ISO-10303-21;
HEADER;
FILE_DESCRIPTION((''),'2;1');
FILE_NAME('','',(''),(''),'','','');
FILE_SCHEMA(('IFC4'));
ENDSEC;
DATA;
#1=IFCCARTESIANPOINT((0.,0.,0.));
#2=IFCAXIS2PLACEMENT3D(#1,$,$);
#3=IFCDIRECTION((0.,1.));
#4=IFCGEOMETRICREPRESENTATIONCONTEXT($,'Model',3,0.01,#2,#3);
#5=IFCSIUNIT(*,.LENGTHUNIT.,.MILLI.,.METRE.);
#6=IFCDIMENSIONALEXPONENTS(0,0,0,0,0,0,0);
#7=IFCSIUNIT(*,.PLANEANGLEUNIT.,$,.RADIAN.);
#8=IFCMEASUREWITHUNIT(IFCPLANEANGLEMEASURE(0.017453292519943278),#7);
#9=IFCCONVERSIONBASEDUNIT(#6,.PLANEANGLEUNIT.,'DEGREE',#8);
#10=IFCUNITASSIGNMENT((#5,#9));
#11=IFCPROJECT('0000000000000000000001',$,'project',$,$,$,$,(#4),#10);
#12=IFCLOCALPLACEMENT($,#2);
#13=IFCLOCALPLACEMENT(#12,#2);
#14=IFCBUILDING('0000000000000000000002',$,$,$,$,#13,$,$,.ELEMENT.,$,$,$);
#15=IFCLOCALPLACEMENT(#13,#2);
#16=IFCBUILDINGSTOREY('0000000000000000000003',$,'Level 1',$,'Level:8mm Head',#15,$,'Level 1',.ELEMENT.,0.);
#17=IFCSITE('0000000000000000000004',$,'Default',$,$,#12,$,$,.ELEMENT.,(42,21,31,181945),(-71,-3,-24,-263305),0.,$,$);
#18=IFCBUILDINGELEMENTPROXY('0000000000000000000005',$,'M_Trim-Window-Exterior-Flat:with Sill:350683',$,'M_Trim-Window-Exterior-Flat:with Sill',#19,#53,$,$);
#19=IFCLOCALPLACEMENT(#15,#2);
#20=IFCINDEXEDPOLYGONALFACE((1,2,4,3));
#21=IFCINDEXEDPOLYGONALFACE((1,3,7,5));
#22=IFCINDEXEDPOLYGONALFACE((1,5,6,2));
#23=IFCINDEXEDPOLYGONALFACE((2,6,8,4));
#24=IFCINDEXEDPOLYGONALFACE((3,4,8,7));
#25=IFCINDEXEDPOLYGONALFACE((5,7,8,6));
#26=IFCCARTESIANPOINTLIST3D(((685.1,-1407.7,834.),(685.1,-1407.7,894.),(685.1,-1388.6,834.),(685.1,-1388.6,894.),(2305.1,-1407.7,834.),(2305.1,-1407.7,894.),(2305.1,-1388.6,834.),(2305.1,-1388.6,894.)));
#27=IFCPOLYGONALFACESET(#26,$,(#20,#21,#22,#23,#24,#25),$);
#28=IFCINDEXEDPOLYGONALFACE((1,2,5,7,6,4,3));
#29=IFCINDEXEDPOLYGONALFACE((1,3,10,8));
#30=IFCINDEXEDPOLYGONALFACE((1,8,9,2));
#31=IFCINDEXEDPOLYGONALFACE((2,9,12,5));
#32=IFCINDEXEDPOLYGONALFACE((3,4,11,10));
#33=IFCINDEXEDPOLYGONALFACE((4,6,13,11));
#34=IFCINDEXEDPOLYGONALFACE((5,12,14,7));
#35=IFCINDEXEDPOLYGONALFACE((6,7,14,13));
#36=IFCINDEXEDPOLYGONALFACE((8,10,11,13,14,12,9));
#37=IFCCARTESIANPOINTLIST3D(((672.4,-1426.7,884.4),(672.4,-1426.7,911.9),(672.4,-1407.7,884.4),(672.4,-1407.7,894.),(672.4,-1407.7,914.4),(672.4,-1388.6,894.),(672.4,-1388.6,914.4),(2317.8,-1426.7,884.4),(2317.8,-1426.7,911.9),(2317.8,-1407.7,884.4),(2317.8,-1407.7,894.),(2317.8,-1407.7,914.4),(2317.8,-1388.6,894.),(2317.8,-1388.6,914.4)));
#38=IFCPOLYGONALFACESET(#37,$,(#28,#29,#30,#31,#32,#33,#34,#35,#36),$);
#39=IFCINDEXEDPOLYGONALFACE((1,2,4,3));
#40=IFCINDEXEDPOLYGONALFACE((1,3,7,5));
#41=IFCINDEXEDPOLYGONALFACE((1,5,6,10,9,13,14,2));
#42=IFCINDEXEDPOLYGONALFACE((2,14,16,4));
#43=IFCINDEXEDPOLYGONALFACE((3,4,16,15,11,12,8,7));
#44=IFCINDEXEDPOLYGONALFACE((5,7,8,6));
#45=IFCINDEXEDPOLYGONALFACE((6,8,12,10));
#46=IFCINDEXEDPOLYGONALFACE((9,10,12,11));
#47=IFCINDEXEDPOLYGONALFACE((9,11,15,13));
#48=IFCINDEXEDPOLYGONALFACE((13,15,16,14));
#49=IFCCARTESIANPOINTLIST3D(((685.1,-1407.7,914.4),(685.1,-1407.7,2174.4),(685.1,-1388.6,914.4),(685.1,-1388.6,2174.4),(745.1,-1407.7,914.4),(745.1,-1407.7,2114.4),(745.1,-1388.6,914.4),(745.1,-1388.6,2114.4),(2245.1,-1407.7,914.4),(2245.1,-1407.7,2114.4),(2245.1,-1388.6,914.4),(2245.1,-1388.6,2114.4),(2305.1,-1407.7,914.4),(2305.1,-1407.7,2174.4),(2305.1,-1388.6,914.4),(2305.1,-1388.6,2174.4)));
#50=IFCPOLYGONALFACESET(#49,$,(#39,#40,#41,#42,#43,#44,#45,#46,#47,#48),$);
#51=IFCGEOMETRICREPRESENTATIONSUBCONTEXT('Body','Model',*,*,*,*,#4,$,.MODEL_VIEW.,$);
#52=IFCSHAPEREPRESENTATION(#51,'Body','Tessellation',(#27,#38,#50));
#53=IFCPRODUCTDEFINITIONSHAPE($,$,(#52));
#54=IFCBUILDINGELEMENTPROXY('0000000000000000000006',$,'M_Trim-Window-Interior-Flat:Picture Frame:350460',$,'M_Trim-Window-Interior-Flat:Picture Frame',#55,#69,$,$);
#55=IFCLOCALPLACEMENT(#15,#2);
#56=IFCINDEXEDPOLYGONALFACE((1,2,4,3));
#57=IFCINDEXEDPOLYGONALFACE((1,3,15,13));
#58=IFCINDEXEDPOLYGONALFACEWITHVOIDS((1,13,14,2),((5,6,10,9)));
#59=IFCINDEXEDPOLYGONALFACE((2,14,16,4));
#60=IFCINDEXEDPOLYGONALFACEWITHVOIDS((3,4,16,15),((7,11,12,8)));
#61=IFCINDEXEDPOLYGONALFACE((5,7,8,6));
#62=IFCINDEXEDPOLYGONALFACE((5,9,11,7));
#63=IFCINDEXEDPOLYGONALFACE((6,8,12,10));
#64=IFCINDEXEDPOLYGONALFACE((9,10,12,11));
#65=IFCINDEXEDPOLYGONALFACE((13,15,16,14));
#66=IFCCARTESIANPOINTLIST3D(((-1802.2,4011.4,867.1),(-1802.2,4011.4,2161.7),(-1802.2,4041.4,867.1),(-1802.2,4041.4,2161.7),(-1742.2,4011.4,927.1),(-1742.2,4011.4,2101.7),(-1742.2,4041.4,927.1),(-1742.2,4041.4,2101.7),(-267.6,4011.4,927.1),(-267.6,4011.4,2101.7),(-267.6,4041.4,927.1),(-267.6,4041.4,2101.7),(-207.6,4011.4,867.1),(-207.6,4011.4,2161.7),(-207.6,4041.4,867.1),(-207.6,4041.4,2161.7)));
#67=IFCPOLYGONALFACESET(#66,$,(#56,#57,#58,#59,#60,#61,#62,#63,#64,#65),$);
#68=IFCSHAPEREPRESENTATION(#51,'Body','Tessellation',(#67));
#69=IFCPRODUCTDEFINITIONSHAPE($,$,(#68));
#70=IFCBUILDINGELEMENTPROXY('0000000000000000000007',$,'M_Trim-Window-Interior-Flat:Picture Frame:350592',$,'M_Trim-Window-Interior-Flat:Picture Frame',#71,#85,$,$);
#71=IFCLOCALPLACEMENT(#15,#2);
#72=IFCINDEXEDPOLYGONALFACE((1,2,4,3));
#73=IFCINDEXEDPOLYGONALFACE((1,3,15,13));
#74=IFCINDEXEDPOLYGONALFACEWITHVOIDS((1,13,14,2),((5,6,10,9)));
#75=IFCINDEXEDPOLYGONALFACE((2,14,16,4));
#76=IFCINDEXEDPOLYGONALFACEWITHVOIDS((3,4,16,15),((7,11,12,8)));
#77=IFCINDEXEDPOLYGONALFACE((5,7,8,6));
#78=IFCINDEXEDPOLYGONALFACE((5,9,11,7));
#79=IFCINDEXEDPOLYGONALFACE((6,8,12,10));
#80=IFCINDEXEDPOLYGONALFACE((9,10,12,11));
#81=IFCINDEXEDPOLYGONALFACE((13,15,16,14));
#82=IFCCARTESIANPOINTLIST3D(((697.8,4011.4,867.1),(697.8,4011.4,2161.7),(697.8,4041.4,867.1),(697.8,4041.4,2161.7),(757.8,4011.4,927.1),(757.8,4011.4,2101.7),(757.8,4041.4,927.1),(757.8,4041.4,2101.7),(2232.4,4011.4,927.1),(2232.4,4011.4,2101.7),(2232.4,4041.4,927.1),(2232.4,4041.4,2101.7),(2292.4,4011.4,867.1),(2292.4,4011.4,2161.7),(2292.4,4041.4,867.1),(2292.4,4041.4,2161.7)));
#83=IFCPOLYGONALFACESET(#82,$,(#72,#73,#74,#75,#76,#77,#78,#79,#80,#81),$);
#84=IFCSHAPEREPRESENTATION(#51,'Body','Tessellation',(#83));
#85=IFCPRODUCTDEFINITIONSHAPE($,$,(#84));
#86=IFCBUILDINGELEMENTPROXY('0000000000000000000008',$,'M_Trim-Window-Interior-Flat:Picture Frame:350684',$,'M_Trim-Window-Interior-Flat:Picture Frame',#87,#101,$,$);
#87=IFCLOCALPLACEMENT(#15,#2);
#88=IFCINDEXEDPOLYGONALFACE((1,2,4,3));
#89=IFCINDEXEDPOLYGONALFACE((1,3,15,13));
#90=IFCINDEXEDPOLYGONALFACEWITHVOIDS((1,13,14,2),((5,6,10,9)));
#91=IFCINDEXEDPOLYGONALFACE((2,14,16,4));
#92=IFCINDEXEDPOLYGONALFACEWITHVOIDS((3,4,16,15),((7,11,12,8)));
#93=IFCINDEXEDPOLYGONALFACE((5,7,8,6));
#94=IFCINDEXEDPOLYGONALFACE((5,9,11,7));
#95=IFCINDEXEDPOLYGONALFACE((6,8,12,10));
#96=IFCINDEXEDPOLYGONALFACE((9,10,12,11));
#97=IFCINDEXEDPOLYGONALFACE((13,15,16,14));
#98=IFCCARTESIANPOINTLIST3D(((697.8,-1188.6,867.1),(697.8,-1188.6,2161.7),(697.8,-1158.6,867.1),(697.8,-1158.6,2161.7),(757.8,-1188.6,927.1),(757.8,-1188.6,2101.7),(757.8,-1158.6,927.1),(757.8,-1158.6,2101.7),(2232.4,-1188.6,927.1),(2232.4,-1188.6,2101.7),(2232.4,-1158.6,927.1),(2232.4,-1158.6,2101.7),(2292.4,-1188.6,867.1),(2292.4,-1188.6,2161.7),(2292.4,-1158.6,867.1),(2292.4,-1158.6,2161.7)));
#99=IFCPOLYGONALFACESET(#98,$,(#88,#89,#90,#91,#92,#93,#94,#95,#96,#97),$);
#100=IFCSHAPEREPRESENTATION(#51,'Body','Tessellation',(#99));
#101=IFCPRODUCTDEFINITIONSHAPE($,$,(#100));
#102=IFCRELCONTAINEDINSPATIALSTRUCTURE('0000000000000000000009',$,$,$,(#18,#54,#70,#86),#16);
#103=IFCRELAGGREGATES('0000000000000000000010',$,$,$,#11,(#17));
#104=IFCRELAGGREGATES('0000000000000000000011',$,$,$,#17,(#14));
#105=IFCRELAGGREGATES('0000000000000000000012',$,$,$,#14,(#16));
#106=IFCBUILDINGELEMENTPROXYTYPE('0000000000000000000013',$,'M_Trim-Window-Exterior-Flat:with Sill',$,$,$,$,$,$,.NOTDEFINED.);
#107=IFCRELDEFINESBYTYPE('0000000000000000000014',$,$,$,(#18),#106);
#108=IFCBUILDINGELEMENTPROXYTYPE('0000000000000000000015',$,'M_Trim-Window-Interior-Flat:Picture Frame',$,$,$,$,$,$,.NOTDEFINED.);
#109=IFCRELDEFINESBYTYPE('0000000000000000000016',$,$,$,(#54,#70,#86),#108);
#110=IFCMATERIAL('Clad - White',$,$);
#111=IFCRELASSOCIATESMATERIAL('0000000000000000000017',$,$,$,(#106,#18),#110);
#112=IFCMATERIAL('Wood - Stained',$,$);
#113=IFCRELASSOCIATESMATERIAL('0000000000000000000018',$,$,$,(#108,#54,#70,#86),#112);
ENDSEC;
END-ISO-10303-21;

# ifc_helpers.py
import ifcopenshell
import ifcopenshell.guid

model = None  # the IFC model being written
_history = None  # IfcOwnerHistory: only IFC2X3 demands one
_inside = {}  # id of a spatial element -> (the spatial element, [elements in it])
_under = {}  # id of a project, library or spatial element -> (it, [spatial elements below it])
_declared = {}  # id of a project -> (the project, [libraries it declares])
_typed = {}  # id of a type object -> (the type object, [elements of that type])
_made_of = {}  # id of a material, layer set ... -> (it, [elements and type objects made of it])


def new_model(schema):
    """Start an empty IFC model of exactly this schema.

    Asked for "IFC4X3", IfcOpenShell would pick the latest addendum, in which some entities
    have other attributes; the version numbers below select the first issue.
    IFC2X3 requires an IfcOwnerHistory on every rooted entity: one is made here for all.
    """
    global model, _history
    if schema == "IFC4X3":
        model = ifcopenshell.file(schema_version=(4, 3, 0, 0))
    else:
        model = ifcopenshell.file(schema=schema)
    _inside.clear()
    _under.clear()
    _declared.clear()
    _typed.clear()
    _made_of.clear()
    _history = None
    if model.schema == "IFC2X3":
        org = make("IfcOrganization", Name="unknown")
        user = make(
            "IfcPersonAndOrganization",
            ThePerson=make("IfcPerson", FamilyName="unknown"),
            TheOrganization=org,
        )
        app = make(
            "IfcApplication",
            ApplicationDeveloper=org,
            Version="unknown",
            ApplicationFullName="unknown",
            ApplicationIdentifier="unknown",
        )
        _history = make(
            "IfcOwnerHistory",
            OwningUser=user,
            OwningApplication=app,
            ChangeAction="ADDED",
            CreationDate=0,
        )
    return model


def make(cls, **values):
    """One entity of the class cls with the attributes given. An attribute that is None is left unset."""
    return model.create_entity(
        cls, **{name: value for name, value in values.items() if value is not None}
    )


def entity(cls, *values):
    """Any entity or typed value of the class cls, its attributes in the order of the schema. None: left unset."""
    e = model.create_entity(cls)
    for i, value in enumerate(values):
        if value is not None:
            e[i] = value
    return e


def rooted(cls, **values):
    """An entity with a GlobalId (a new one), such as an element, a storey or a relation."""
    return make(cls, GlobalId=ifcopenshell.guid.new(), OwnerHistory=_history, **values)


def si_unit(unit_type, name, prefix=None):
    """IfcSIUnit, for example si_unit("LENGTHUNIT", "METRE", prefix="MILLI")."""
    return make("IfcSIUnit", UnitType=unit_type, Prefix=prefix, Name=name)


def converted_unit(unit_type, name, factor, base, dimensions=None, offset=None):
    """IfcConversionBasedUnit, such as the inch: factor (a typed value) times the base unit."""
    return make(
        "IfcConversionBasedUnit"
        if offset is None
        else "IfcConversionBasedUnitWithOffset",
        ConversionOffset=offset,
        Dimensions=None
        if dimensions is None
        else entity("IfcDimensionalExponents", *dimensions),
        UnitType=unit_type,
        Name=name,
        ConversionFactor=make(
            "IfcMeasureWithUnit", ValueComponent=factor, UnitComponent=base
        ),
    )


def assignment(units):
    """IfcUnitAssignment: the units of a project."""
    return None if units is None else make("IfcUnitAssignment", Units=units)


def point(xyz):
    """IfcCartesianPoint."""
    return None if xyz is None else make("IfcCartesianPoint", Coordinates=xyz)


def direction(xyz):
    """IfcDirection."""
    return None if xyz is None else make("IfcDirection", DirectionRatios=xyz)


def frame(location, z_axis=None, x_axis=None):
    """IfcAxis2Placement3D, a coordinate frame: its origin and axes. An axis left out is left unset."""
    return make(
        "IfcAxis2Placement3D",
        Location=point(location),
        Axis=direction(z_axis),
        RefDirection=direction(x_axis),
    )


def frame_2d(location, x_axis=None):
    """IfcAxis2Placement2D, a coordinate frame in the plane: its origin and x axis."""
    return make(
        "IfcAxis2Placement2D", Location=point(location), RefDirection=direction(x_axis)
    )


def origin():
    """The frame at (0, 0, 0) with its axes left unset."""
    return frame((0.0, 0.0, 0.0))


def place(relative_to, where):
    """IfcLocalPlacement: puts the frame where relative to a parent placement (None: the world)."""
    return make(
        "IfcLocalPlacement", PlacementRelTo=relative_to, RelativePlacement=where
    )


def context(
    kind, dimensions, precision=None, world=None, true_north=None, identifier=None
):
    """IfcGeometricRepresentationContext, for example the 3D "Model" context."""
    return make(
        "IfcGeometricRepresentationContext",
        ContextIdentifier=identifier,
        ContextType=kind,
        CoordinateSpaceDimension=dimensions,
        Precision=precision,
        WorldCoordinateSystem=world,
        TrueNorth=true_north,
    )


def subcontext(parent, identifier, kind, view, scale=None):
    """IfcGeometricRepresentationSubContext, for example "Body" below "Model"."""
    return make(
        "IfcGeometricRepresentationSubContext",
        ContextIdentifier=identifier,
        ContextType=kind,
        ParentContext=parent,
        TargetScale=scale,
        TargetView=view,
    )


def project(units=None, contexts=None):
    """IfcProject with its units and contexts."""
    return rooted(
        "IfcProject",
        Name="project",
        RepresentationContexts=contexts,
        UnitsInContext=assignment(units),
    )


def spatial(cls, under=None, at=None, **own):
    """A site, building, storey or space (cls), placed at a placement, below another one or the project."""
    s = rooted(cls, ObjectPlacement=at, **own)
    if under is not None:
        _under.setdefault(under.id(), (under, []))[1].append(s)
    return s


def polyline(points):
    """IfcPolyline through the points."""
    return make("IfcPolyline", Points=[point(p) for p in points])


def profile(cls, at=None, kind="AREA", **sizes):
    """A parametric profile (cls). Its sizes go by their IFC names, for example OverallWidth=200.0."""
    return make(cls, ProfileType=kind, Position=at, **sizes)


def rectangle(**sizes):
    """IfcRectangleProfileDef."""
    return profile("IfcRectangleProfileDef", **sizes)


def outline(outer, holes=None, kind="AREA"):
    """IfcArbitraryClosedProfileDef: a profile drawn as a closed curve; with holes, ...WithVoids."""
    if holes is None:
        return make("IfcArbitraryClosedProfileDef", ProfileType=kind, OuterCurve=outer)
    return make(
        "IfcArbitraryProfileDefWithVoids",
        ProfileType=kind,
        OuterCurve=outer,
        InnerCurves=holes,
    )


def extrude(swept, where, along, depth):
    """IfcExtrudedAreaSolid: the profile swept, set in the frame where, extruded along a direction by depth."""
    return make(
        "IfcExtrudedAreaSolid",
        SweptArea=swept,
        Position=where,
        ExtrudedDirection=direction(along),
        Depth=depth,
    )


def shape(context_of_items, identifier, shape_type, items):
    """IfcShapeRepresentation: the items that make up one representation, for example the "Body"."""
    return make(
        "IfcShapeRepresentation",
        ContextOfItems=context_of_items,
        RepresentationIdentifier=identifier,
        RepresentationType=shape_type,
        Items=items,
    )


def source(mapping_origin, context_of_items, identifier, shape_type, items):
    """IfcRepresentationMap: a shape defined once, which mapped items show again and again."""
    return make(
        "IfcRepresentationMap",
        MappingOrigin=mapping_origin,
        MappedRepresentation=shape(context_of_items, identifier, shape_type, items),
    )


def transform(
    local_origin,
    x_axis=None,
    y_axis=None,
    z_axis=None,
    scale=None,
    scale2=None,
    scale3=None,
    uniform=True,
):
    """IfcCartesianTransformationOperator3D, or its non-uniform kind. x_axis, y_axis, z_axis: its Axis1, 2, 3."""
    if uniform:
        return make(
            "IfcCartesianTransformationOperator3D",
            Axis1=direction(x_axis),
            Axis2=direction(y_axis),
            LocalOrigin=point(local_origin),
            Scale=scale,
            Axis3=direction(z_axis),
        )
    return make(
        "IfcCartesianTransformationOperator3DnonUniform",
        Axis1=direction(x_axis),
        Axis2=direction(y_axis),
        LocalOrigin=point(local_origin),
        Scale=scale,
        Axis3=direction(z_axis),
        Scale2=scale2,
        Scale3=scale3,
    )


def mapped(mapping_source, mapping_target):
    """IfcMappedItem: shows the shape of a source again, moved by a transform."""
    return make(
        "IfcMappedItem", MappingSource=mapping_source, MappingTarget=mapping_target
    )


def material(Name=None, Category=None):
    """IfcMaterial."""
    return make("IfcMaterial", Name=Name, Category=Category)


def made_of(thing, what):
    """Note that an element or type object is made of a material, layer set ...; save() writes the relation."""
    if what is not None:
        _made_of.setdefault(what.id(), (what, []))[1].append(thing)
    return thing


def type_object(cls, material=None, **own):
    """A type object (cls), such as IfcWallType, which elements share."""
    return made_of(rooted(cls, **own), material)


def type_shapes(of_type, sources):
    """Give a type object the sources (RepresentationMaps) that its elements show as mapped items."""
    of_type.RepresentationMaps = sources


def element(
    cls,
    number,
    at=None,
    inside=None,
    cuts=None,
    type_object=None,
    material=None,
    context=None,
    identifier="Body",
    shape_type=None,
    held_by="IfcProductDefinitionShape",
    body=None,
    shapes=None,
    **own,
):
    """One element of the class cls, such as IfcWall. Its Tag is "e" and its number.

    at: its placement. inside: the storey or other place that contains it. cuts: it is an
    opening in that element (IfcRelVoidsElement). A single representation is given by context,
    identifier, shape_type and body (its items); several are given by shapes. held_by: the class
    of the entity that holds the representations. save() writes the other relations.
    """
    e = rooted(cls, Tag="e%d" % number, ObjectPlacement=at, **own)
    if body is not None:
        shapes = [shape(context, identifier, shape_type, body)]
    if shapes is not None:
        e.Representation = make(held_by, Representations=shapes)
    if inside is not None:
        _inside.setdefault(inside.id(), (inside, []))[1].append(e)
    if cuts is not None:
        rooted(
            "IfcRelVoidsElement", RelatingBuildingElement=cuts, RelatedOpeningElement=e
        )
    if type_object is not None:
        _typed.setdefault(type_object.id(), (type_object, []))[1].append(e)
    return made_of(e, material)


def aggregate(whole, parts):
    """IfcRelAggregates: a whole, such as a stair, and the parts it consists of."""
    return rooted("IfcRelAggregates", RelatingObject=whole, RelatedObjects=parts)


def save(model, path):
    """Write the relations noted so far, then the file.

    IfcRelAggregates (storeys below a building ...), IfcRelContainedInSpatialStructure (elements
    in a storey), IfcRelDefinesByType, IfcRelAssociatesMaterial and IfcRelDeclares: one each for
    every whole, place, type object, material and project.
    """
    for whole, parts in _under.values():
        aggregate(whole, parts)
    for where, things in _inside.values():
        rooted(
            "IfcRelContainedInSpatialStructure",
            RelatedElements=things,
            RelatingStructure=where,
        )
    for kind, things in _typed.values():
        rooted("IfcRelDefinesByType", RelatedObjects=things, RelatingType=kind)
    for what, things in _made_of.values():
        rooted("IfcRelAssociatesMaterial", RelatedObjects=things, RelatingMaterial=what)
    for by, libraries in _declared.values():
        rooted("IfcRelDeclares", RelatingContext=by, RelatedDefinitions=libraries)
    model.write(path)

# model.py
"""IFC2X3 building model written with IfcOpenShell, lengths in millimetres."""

from ifc_helpers import new_model, entity, si_unit, converted_unit, direction, frame, frame_2d, origin, place, context, subcontext, project, spatial, polyline, rectangle, outline, extrude, source, transform, mapped, material, type_object, type_shapes, element, save


model = new_model("IFC2X3")

# Units and contexts
model_context = context("Model", 3, precision=0.01, world=origin(), true_north=direction((0.0, 1.0)))
body_context = subcontext(model_context, "Body", "Model", "MODEL_VIEW")
ifc_project = project(units=[si_unit("LENGTHUNIT", "METRE", prefix="MILLI"), converted_unit("PLANEANGLEUNIT", "DEGREE", entity("IfcPlaneAngleMeasure", 0.017453292519943278), si_unit("PLANEANGLEUNIT", "RADIAN"), dimensions=[0, 0, 0, 0, 0, 0, 0])], contexts=[model_context])

# Site, building, storey
site_placement = place(None, origin())
site = spatial("IfcSite", under=ifc_project, at=site_placement, Name="Default", CompositionType="ELEMENT", RefLatitude=(42, 21, 31, 181945), RefLongitude=(-71, -3, -24, -263305), RefElevation=0.0)
building_placement = place(site_placement, origin())
building = spatial("IfcBuilding", under=site, at=building_placement, CompositionType="ELEMENT")
storey_placement = place(building_placement, origin())
storey = spatial("IfcBuildingStorey", under=building, at=storey_placement, Name="Level 1", ObjectType="Level:8mm Head", LongName="Level 1", CompositionType="ELEMENT", Elevation=0.0)

# Shared definitions
ifc_material_1 = material(Name="Wood - Stained")

# Building element proxies
ifc_material_2 = material(Name="Clad - White")
building_element_proxy_type_1 = type_object("IfcBuildingElementProxyType", Name="M_Trim-Window-Exterior-Flat:with Sill", PredefinedType="NOTDEFINED", material=ifc_material_2)
shared_shape_1 = source(origin(), body_context, "Body", "SweptSolid", [
    extrude(rectangle(XDim=1620.0, YDim=60.0, at=frame_2d((0.0, 0.0), x_axis=(1.0, 0.0))), frame((0.0, -1250.4, 0.0), z_axis=(0.0, 0.0, 1.0), x_axis=(-1.0, 0.0, 0.0)), (0.0, 0.0, 1.0), 19.0),
    extrude(outline(polyline([(-19.0, -15.2), (0.0, -15.2), (0.0, -5.7), (19.0, -5.7), (19.0, 14.8), (0.0, 14.8), (-19.0, 12.3), (-19.0, -15.2)])), frame((-822.7, -1214.8, 19.0), z_axis=(1.0, 0.0, 0.0), x_axis=(0.0, 0.0, -1.0)), (0.0, 0.0, 1.0), 1645.4),
    extrude(outline(polyline([(-645.0, -810.0), (615.0, -810.0), (615.0, -750.0), (-585.0, -750.0), (-585.0, 750.0), (615.0, 750.0), (615.0, 810.0), (-645.0, 810.0), (-645.0, -810.0)])), frame((0.0, -585.0, 0.0), z_axis=(0.0, 0.0, 1.0), x_axis=(0.0, -1.0, 0.0)), (0.0, 0.0, 1.0), 19.0),
])
type_shapes(building_element_proxy_type_1, [shared_shape_1])
for number, where, z_axis, x_axis, name in (
    (1, (1495.1, -1388.6, 2114.4), (0.0, -1.0, 0.0), (1.0, 0.0, 0.0), "M_Trim-Window-Exterior-Flat:with Sill:350683"),
):
    element("IfcBuildingElementProxy", number, at=place(storey_placement, frame(where, z_axis=z_axis, x_axis=x_axis)), inside=storey, type_object=building_element_proxy_type_1, material=ifc_material_2, Name=name, ObjectType="M_Trim-Window-Exterior-Flat:with Sill", context=body_context, shape_type="MappedRepresentation", body=[
        mapped(shared_shape_1, transform((0.0, 0.0, 0.0), scale=1.0)),
    ])
building_element_proxy_type_2 = type_object("IfcBuildingElementProxyType", Name="M_Trim-Window-Interior-Flat:Picture Frame", PredefinedType="NOTDEFINED", material=ifc_material_1)
shared_shape_2 = source(origin(), body_context, "Body", "SweptSolid", [
    extrude(outline(polyline([(-797.3, -647.3), (797.3, -647.3), (797.3, 647.3), (-797.3, 647.3), (-797.3, -647.3)]), holes=[polyline([(-737.3, -587.3), (-737.3, 587.3), (737.3, 587.3), (737.3, -587.3), (-737.3, -587.3)])]), frame((0.0, -600.0, 0.0), z_axis=(0.0, 0.0, 1.0), x_axis=(-1.0, 0.0, 0.0)), (0.0, 0.0, 1.0), 30.0),
])
type_shapes(building_element_proxy_type_2, [shared_shape_2])
for number, where, z_axis, x_axis, name in (
    (2, (-1004.9, 4011.4, 2114.4), (0.0, 1.0, 0.0), (-1.0, 0.0, 0.0), "M_Trim-Window-Interior-Flat:Picture Frame:350460"),
    (3, (1495.1, 4011.4, 2114.4), (0.0, 1.0, 0.0), (-1.0, 0.0, 0.0), "M_Trim-Window-Interior-Flat:Picture Frame:350592"),
    (4, (1495.1, -1188.6, 2114.4), (0.0, 1.0, 0.0), (-1.0, 0.0, 0.0), "M_Trim-Window-Interior-Flat:Picture Frame:350684"),
):
    element("IfcBuildingElementProxy", number, at=place(storey_placement, frame(where, z_axis=z_axis, x_axis=x_axis)), inside=storey, type_object=building_element_proxy_type_2, material=ifc_material_1, Name=name, ObjectType="M_Trim-Window-Interior-Flat:Picture Frame", context=body_context, shape_type="MappedRepresentation", body=[
        mapped(shared_shape_2, transform((0.0, 0.0, 0.0), scale=1.0)),
    ])

save(model, "model.ifc")
